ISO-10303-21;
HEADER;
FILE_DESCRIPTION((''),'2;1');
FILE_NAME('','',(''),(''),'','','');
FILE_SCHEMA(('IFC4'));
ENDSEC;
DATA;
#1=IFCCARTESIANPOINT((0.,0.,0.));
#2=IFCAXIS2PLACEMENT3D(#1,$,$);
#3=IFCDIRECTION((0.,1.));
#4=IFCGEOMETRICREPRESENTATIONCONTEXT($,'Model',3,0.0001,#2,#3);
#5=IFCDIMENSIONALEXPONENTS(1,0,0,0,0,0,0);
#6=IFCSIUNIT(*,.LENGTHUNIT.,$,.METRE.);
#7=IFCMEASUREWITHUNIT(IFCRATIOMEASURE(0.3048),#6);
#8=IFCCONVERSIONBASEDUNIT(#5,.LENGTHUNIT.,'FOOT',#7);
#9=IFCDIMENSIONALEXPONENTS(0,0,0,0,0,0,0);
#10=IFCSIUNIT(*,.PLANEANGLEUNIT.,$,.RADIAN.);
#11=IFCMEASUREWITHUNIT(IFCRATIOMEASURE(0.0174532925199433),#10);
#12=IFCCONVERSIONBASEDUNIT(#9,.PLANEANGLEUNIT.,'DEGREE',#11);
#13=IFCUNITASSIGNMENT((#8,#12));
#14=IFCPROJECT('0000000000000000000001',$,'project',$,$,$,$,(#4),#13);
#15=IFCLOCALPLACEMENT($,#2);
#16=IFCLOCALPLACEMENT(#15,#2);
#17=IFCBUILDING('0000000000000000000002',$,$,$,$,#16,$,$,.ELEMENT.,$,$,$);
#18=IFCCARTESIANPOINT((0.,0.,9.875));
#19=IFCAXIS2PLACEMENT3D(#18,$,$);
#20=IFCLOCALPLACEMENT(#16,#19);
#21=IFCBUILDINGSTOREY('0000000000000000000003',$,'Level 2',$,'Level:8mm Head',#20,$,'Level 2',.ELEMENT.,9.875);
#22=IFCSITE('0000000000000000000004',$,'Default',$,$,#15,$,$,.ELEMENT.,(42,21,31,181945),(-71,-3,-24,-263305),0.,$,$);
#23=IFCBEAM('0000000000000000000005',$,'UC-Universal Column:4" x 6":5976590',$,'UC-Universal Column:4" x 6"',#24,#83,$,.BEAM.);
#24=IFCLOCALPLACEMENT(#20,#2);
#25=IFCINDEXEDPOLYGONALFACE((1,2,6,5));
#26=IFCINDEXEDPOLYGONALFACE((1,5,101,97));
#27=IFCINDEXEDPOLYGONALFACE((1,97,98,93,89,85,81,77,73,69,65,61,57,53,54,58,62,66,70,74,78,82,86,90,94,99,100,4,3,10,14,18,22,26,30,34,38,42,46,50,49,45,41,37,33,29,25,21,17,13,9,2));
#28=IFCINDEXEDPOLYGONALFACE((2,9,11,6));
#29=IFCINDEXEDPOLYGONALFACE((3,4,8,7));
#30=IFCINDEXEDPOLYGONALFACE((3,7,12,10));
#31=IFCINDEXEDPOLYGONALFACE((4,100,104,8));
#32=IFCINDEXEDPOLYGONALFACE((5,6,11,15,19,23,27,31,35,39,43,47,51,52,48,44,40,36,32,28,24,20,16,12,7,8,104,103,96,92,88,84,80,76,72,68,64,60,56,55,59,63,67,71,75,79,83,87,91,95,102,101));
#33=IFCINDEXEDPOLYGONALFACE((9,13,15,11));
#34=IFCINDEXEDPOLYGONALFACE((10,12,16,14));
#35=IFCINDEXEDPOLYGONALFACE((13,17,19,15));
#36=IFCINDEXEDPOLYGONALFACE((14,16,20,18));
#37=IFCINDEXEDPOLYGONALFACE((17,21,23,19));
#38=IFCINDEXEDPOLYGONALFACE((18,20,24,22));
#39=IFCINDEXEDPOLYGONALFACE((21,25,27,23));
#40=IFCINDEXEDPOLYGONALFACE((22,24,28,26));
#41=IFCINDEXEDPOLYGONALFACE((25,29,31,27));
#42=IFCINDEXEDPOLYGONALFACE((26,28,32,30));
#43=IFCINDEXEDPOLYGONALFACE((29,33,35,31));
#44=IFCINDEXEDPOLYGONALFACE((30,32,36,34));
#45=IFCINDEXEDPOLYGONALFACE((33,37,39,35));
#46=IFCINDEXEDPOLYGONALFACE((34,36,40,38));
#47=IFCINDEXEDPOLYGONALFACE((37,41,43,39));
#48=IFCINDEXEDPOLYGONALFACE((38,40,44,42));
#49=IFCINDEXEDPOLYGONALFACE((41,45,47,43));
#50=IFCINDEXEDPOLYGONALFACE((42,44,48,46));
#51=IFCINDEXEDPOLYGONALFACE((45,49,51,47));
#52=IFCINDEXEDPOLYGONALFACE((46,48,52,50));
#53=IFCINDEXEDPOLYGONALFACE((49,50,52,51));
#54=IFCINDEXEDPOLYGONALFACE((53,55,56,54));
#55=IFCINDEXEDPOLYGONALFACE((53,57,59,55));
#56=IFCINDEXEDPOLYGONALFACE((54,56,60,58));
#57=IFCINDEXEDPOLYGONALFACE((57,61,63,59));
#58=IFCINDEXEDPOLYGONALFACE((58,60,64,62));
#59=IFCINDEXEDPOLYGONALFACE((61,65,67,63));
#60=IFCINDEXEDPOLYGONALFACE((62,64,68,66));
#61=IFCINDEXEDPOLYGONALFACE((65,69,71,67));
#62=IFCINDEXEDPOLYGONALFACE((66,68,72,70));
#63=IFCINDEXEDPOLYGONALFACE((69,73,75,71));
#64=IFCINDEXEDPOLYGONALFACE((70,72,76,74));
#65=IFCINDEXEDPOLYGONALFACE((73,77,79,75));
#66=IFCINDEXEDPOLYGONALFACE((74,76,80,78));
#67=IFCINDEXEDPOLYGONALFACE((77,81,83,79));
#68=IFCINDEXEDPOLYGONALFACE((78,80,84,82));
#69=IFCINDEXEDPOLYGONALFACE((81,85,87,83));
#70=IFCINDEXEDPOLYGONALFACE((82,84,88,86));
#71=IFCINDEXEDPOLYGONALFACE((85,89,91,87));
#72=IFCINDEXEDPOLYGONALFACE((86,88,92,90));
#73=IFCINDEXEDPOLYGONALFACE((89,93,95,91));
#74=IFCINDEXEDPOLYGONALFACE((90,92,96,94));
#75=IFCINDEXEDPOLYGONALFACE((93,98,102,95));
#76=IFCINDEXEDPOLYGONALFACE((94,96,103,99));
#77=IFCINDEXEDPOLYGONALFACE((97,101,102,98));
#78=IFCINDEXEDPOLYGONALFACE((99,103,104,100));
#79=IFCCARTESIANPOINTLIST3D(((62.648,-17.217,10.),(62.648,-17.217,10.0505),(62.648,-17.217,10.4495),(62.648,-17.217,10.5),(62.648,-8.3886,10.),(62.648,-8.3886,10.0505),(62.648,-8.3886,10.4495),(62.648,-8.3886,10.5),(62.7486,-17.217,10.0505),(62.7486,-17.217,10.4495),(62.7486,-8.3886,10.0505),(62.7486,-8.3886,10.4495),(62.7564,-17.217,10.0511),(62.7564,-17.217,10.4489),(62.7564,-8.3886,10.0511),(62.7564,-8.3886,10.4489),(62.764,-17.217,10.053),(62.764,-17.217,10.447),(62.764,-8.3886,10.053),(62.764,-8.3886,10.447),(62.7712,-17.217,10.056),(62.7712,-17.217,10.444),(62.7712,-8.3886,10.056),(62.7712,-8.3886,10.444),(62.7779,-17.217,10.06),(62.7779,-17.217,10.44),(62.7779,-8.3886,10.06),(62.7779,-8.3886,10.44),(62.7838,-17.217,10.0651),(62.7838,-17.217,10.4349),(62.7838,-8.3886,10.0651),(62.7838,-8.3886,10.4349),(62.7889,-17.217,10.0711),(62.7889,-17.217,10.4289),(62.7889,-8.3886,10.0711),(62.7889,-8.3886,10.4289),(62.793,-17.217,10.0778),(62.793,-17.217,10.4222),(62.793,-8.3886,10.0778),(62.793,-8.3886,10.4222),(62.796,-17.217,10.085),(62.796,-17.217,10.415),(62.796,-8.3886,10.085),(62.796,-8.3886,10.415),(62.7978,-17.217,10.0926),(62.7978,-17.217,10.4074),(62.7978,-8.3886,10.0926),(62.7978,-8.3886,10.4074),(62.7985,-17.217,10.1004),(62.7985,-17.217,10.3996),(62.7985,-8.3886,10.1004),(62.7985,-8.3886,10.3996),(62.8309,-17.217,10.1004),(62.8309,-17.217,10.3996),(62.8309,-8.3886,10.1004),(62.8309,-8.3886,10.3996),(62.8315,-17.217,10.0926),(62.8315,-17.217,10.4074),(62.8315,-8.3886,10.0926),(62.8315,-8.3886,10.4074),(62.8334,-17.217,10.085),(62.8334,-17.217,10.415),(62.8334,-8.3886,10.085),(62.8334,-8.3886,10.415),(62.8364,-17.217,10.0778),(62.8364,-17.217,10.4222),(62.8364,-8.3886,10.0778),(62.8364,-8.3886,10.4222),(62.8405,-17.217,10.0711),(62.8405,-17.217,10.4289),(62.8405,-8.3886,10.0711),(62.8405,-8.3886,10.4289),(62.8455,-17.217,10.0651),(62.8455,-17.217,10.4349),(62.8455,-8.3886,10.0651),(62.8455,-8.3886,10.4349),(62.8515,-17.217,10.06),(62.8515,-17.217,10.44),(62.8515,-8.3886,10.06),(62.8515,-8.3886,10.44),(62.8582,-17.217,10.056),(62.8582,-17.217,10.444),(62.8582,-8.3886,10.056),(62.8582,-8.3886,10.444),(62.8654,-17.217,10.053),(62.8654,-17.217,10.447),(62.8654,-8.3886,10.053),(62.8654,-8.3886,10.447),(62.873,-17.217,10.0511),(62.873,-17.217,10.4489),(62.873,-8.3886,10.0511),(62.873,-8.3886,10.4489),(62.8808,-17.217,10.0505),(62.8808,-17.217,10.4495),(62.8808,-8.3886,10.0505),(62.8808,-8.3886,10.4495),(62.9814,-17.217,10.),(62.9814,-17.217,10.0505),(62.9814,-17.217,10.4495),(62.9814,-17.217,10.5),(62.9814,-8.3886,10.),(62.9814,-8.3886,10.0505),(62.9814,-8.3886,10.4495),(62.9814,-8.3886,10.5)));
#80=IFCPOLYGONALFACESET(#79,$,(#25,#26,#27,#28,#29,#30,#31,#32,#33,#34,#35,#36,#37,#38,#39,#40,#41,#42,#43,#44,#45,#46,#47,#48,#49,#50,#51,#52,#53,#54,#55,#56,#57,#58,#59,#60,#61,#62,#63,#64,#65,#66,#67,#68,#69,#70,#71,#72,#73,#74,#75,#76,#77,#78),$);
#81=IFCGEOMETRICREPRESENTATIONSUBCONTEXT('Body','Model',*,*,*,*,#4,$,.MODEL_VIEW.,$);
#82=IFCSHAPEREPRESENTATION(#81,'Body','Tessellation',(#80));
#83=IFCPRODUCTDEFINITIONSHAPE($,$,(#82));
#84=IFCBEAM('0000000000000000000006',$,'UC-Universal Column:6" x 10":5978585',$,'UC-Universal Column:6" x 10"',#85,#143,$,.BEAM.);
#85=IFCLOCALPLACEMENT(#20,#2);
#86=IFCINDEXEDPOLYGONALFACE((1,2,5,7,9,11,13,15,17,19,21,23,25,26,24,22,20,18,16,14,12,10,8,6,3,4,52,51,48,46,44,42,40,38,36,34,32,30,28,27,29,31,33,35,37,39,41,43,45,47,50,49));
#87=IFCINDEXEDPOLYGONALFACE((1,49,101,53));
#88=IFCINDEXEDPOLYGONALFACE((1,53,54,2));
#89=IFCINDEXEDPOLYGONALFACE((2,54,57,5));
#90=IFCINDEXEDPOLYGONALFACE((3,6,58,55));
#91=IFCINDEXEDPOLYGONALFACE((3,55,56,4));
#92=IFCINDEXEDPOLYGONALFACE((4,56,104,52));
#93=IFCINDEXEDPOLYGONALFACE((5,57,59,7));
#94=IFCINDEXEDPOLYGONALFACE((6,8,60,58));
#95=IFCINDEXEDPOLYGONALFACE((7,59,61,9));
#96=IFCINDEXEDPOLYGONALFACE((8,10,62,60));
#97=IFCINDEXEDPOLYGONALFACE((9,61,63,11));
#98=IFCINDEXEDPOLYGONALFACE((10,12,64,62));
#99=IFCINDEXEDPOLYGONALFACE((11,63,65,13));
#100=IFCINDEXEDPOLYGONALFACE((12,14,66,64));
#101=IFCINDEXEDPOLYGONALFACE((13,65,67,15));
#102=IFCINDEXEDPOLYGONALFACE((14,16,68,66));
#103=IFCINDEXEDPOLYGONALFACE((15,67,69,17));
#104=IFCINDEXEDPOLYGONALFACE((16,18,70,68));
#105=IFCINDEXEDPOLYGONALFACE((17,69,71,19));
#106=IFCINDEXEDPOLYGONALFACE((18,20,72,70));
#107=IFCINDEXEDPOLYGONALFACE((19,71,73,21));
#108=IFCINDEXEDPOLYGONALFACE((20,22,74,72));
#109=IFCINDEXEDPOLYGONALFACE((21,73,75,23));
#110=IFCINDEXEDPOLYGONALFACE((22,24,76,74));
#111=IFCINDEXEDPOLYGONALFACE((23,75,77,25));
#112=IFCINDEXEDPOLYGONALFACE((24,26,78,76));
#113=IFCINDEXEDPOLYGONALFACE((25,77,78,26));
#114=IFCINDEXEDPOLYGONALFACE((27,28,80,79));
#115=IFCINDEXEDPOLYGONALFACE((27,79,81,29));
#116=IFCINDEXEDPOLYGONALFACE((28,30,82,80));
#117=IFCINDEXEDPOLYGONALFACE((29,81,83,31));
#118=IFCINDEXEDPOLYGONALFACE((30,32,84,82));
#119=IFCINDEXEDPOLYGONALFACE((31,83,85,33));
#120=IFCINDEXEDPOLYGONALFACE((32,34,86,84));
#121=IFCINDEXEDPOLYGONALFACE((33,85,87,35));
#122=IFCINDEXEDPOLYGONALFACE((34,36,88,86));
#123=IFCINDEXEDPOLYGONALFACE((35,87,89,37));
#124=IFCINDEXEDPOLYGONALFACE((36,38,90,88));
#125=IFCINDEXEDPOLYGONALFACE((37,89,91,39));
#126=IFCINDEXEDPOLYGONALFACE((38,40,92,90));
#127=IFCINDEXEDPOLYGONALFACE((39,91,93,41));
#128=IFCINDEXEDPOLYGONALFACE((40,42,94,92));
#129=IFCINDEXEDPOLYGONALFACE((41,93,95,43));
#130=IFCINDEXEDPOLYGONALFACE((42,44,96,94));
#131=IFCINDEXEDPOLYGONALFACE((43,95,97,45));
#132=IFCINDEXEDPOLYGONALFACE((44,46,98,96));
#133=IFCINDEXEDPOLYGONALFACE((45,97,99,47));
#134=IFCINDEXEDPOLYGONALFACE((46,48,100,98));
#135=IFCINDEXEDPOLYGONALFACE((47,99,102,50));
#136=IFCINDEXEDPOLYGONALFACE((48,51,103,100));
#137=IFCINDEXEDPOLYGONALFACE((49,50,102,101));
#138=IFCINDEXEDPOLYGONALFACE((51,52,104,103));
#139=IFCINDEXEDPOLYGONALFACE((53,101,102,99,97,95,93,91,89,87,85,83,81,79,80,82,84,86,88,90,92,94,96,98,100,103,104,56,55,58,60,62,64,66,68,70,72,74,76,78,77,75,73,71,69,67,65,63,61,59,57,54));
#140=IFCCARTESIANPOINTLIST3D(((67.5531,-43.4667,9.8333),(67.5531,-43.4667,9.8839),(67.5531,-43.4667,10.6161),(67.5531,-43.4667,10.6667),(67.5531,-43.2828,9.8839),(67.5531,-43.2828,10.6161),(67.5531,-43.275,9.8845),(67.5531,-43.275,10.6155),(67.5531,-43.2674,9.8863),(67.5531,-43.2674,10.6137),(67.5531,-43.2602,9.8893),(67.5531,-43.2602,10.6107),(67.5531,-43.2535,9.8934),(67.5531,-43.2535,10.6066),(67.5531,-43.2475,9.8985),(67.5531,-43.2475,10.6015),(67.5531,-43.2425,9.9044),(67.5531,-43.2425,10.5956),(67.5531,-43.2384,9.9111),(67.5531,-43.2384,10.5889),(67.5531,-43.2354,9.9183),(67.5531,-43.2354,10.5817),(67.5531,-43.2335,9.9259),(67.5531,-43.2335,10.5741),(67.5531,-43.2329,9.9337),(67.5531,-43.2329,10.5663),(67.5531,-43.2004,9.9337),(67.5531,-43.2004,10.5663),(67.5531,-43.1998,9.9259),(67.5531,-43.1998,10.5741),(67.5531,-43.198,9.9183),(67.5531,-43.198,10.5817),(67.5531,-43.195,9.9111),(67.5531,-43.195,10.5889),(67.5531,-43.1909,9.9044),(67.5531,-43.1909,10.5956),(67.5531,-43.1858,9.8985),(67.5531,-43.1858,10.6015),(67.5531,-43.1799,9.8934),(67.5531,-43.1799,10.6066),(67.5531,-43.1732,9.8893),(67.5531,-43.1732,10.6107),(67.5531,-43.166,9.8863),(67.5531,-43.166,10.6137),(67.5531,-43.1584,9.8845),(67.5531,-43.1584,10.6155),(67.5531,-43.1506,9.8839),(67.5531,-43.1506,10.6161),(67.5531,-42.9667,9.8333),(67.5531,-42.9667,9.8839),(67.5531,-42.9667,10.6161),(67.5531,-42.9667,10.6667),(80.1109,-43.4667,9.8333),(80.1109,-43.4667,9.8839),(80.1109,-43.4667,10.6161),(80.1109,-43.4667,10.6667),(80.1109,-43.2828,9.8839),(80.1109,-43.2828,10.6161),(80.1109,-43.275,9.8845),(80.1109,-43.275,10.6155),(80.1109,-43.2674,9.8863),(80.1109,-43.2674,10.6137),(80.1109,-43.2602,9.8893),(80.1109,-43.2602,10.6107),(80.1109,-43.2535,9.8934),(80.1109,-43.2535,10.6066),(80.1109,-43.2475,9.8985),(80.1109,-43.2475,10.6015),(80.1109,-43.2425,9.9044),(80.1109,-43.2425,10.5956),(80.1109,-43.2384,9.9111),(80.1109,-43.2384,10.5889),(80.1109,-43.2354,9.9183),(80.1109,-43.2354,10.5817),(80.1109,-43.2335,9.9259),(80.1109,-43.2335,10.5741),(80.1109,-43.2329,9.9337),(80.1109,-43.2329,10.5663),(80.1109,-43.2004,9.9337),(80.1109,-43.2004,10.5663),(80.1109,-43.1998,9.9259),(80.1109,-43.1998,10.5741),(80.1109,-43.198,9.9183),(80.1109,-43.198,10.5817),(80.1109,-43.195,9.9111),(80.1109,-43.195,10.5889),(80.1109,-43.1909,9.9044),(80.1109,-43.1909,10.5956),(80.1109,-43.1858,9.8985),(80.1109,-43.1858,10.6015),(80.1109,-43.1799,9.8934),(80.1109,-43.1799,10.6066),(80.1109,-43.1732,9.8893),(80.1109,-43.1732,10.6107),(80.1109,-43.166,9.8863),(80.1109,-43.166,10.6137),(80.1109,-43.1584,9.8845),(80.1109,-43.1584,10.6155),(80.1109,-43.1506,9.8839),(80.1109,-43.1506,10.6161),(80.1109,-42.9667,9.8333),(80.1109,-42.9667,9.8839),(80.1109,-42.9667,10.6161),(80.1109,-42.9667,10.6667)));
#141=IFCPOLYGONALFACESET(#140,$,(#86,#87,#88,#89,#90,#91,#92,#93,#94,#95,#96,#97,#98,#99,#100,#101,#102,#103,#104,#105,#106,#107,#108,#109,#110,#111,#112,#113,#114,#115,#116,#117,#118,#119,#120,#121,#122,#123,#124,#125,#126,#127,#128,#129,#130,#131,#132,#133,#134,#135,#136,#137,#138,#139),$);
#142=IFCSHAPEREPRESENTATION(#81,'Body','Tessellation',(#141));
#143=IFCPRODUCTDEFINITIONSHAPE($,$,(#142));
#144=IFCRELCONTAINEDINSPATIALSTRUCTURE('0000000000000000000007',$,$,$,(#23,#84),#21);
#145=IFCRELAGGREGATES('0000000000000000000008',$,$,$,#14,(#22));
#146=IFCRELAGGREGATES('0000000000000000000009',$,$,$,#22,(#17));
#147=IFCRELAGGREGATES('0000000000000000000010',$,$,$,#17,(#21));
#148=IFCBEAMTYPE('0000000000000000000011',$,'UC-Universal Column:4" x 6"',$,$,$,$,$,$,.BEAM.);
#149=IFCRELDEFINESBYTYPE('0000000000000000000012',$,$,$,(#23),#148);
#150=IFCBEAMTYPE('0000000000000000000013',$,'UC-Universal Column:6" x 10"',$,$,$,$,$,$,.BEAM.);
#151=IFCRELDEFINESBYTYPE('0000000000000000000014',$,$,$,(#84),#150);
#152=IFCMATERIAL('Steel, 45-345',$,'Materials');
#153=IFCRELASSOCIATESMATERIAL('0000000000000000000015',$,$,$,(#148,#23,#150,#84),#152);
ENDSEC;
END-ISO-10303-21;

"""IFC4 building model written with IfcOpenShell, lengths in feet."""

from ifc_helpers import new_model, entity, si_unit, converted_unit, direction, frame, origin, place, context, subcontext, project, spatial, indexed_curve, outline, extrude, source, transform, mapped, material, type_object, type_shapes, element, save


model = new_model("IFC4")

# Units and contexts
model_context = context("Model", 3, precision=0.0001, world=origin(), true_north=direction((0.0, 1.0)))
body_context = subcontext(model_context, "Body", "Model", "MODEL_VIEW")
ifc_project = project(units=[converted_unit("LENGTHUNIT", "FOOT", entity("IfcRatioMeasure", 0.3048), si_unit("LENGTHUNIT", "METRE"), dimensions=[1, 0, 0, 0, 0, 0, 0]), converted_unit("PLANEANGLEUNIT", "DEGREE", entity("IfcRatioMeasure", 0.0174532925199433), si_unit("PLANEANGLEUNIT", "RADIAN"), dimensions=[0, 0, 0, 0, 0, 0, 0])], contexts=[model_context])

# Site, building, storey
site_placement = place(None, origin())
site = spatial("IfcSite", under=ifc_project, at=site_placement, Name="Default", CompositionType="ELEMENT", RefLatitude=(42, 21, 31, 181945), RefLongitude=(-71, -3, -24, -263305), RefElevation=0.0)
building_placement = place(site_placement, origin())
building = spatial("IfcBuilding", under=site, at=building_placement, CompositionType="ELEMENT")
storey_placement = place(building_placement, frame((0.0, 0.0, 9.875)))
storey = spatial("IfcBuildingStorey", under=building, at=storey_placement, Name="Level 2", ObjectType="Level:8mm Head", LongName="Level 2", CompositionType="ELEMENT", Elevation=9.875)

# Beams
ifc_material_1 = material(Name="Steel, 45-345", Category="Materials")
beam_type_1 = type_object("IfcBeamType", Name="UC-Universal Column:4\" x 6\"", PredefinedType="BEAM", material=ifc_material_1)
shared_shape_1 = source(origin(), body_context, "Body", "SweptSolid", [
    extrude(outline(indexed_curve([(-0.25, -0.1667), (-0.1995, -0.1667), (-0.1995, -0.0661), (-0.1989, -0.0583), (-0.197, -0.0507), (-0.194, -0.0435), (-0.19, -0.0368), (-0.1849, -0.0308), (-0.1789, -0.0258), (-0.1722, -0.0217), (-0.165, -0.0187), (-0.1574, -0.0169), (-0.1496, -0.0162), (0.1496, -0.0162), (0.1574, -0.0169), (0.165, -0.0187), (0.1722, -0.0217), (0.1789, -0.0258), (0.1849, -0.0308), (0.19, -0.0368), (0.194, -0.0435), (0.197, -0.0507), (0.1989, -0.0583), (0.1995, -0.0661), (0.1995, -0.1667), (0.25, -0.1667), (0.25, 0.1667), (0.1995, 0.1667), (0.1995, 0.0661), (0.1989, 0.0583), (0.197, 0.0507), (0.194, 0.0435), (0.19, 0.0368), (0.1849, 0.0308), (0.1789, 0.0258), (0.1722, 0.0217), (0.165, 0.0187), (0.1574, 0.0169), (0.1496, 0.0162), (-0.1496, 0.0162), (-0.1574, 0.0169), (-0.165, 0.0187), (-0.1722, 0.0217), (-0.1789, 0.0258), (-0.1849, 0.0308), (-0.19, 0.0368), (-0.194, 0.0435), (-0.197, 0.0507), (-0.1989, 0.0583), (-0.1995, 0.0661), (-0.1995, 0.1667), (-0.25, 0.1667), (-0.25, -0.1667)], self_intersect=False)), frame((43.8604, 0.0, 0.0), z_axis=(1.0, 0.0, 0.0), x_axis=(0.0, 0.0, -1.0)), (0.0, 0.0, 1.0), 8.8284),
])
type_shapes(beam_type_1, [shared_shape_1])
beam_1_placement = place(storey_placement, frame((62.8147, -61.0774, 10.25), z_axis=(0.0, 0.0, 1.0), x_axis=(0.0, 1.0, 0.0)))
element("IfcBeam", 1, at=beam_1_placement, inside=storey, type_object=beam_type_1, material=ifc_material_1, Name="UC-Universal Column:4\" x 6\":5976590", ObjectType="UC-Universal Column:4\" x 6\"", PredefinedType="BEAM", context=body_context, shape_type="MappedRepresentation", body=[
    mapped(shared_shape_1, transform((0.0, 0.0, 0.0), scale=1.0)),
])
beam_type_2 = type_object("IfcBeamType", Name="UC-Universal Column:6\" x 10\"", PredefinedType="BEAM", material=ifc_material_1)
shared_shape_2 = source(origin(), body_context, "Body", "SweptSolid", [
    extrude(outline(indexed_curve([(-0.4167, -0.25), (-0.3661, -0.25), (-0.3661, -0.0661), (-0.3655, -0.0583), (-0.3637, -0.0507), (-0.3607, -0.0435), (-0.3566, -0.0368), (-0.3515, -0.0308), (-0.3456, -0.0258), (-0.3389, -0.0217), (-0.3317, -0.0187), (-0.3241, -0.0169), (-0.3163, -0.0162), (0.3163, -0.0162), (0.3241, -0.0169), (0.3317, -0.0187), (0.3389, -0.0217), (0.3456, -0.0258), (0.3515, -0.0308), (0.3566, -0.0368), (0.3607, -0.0435), (0.3637, -0.0507), (0.3655, -0.0583), (0.3661, -0.0661), (0.3661, -0.25), (0.4167, -0.25), (0.4167, 0.25), (0.3661, 0.25), (0.3661, 0.0661), (0.3655, 0.0583), (0.3637, 0.0507), (0.3607, 0.0435), (0.3566, 0.0368), (0.3515, 0.0308), (0.3456, 0.0258), (0.3389, 0.0217), (0.3317, 0.0187), (0.3241, 0.0169), (0.3163, 0.0162), (-0.3163, 0.0162), (-0.3241, 0.0169), (-0.3317, 0.0187), (-0.3389, 0.0217), (-0.3456, 0.0258), (-0.3515, 0.0308), (-0.3566, 0.0368), (-0.3607, 0.0435), (-0.3637, 0.0507), (-0.3655, 0.0583), (-0.3661, 0.0661), (-0.3661, 0.25), (-0.4167, 0.25), (-0.4167, -0.25)], self_intersect=False)), frame((-4.5742, 0.0, 0.0), z_axis=(1.0, 0.0, 0.0), x_axis=(0.0, 0.0, -1.0)), (0.0, 0.0, 1.0), 12.5577),
])
type_shapes(beam_type_2, [shared_shape_2])
beam_2_placement = place(storey_placement, frame((72.1273, -43.2167, 10.25)))
element("IfcBeam", 2, at=beam_2_placement, inside=storey, type_object=beam_type_2, material=ifc_material_1, Name="UC-Universal Column:6\" x 10\":5978585", ObjectType="UC-Universal Column:6\" x 10\"", PredefinedType="BEAM", context=body_context, shape_type="MappedRepresentation", body=[
    mapped(shared_shape_2, transform((0.0, 0.0, 0.0), scale=1.0)),
])

save(model, "model.ifc")
